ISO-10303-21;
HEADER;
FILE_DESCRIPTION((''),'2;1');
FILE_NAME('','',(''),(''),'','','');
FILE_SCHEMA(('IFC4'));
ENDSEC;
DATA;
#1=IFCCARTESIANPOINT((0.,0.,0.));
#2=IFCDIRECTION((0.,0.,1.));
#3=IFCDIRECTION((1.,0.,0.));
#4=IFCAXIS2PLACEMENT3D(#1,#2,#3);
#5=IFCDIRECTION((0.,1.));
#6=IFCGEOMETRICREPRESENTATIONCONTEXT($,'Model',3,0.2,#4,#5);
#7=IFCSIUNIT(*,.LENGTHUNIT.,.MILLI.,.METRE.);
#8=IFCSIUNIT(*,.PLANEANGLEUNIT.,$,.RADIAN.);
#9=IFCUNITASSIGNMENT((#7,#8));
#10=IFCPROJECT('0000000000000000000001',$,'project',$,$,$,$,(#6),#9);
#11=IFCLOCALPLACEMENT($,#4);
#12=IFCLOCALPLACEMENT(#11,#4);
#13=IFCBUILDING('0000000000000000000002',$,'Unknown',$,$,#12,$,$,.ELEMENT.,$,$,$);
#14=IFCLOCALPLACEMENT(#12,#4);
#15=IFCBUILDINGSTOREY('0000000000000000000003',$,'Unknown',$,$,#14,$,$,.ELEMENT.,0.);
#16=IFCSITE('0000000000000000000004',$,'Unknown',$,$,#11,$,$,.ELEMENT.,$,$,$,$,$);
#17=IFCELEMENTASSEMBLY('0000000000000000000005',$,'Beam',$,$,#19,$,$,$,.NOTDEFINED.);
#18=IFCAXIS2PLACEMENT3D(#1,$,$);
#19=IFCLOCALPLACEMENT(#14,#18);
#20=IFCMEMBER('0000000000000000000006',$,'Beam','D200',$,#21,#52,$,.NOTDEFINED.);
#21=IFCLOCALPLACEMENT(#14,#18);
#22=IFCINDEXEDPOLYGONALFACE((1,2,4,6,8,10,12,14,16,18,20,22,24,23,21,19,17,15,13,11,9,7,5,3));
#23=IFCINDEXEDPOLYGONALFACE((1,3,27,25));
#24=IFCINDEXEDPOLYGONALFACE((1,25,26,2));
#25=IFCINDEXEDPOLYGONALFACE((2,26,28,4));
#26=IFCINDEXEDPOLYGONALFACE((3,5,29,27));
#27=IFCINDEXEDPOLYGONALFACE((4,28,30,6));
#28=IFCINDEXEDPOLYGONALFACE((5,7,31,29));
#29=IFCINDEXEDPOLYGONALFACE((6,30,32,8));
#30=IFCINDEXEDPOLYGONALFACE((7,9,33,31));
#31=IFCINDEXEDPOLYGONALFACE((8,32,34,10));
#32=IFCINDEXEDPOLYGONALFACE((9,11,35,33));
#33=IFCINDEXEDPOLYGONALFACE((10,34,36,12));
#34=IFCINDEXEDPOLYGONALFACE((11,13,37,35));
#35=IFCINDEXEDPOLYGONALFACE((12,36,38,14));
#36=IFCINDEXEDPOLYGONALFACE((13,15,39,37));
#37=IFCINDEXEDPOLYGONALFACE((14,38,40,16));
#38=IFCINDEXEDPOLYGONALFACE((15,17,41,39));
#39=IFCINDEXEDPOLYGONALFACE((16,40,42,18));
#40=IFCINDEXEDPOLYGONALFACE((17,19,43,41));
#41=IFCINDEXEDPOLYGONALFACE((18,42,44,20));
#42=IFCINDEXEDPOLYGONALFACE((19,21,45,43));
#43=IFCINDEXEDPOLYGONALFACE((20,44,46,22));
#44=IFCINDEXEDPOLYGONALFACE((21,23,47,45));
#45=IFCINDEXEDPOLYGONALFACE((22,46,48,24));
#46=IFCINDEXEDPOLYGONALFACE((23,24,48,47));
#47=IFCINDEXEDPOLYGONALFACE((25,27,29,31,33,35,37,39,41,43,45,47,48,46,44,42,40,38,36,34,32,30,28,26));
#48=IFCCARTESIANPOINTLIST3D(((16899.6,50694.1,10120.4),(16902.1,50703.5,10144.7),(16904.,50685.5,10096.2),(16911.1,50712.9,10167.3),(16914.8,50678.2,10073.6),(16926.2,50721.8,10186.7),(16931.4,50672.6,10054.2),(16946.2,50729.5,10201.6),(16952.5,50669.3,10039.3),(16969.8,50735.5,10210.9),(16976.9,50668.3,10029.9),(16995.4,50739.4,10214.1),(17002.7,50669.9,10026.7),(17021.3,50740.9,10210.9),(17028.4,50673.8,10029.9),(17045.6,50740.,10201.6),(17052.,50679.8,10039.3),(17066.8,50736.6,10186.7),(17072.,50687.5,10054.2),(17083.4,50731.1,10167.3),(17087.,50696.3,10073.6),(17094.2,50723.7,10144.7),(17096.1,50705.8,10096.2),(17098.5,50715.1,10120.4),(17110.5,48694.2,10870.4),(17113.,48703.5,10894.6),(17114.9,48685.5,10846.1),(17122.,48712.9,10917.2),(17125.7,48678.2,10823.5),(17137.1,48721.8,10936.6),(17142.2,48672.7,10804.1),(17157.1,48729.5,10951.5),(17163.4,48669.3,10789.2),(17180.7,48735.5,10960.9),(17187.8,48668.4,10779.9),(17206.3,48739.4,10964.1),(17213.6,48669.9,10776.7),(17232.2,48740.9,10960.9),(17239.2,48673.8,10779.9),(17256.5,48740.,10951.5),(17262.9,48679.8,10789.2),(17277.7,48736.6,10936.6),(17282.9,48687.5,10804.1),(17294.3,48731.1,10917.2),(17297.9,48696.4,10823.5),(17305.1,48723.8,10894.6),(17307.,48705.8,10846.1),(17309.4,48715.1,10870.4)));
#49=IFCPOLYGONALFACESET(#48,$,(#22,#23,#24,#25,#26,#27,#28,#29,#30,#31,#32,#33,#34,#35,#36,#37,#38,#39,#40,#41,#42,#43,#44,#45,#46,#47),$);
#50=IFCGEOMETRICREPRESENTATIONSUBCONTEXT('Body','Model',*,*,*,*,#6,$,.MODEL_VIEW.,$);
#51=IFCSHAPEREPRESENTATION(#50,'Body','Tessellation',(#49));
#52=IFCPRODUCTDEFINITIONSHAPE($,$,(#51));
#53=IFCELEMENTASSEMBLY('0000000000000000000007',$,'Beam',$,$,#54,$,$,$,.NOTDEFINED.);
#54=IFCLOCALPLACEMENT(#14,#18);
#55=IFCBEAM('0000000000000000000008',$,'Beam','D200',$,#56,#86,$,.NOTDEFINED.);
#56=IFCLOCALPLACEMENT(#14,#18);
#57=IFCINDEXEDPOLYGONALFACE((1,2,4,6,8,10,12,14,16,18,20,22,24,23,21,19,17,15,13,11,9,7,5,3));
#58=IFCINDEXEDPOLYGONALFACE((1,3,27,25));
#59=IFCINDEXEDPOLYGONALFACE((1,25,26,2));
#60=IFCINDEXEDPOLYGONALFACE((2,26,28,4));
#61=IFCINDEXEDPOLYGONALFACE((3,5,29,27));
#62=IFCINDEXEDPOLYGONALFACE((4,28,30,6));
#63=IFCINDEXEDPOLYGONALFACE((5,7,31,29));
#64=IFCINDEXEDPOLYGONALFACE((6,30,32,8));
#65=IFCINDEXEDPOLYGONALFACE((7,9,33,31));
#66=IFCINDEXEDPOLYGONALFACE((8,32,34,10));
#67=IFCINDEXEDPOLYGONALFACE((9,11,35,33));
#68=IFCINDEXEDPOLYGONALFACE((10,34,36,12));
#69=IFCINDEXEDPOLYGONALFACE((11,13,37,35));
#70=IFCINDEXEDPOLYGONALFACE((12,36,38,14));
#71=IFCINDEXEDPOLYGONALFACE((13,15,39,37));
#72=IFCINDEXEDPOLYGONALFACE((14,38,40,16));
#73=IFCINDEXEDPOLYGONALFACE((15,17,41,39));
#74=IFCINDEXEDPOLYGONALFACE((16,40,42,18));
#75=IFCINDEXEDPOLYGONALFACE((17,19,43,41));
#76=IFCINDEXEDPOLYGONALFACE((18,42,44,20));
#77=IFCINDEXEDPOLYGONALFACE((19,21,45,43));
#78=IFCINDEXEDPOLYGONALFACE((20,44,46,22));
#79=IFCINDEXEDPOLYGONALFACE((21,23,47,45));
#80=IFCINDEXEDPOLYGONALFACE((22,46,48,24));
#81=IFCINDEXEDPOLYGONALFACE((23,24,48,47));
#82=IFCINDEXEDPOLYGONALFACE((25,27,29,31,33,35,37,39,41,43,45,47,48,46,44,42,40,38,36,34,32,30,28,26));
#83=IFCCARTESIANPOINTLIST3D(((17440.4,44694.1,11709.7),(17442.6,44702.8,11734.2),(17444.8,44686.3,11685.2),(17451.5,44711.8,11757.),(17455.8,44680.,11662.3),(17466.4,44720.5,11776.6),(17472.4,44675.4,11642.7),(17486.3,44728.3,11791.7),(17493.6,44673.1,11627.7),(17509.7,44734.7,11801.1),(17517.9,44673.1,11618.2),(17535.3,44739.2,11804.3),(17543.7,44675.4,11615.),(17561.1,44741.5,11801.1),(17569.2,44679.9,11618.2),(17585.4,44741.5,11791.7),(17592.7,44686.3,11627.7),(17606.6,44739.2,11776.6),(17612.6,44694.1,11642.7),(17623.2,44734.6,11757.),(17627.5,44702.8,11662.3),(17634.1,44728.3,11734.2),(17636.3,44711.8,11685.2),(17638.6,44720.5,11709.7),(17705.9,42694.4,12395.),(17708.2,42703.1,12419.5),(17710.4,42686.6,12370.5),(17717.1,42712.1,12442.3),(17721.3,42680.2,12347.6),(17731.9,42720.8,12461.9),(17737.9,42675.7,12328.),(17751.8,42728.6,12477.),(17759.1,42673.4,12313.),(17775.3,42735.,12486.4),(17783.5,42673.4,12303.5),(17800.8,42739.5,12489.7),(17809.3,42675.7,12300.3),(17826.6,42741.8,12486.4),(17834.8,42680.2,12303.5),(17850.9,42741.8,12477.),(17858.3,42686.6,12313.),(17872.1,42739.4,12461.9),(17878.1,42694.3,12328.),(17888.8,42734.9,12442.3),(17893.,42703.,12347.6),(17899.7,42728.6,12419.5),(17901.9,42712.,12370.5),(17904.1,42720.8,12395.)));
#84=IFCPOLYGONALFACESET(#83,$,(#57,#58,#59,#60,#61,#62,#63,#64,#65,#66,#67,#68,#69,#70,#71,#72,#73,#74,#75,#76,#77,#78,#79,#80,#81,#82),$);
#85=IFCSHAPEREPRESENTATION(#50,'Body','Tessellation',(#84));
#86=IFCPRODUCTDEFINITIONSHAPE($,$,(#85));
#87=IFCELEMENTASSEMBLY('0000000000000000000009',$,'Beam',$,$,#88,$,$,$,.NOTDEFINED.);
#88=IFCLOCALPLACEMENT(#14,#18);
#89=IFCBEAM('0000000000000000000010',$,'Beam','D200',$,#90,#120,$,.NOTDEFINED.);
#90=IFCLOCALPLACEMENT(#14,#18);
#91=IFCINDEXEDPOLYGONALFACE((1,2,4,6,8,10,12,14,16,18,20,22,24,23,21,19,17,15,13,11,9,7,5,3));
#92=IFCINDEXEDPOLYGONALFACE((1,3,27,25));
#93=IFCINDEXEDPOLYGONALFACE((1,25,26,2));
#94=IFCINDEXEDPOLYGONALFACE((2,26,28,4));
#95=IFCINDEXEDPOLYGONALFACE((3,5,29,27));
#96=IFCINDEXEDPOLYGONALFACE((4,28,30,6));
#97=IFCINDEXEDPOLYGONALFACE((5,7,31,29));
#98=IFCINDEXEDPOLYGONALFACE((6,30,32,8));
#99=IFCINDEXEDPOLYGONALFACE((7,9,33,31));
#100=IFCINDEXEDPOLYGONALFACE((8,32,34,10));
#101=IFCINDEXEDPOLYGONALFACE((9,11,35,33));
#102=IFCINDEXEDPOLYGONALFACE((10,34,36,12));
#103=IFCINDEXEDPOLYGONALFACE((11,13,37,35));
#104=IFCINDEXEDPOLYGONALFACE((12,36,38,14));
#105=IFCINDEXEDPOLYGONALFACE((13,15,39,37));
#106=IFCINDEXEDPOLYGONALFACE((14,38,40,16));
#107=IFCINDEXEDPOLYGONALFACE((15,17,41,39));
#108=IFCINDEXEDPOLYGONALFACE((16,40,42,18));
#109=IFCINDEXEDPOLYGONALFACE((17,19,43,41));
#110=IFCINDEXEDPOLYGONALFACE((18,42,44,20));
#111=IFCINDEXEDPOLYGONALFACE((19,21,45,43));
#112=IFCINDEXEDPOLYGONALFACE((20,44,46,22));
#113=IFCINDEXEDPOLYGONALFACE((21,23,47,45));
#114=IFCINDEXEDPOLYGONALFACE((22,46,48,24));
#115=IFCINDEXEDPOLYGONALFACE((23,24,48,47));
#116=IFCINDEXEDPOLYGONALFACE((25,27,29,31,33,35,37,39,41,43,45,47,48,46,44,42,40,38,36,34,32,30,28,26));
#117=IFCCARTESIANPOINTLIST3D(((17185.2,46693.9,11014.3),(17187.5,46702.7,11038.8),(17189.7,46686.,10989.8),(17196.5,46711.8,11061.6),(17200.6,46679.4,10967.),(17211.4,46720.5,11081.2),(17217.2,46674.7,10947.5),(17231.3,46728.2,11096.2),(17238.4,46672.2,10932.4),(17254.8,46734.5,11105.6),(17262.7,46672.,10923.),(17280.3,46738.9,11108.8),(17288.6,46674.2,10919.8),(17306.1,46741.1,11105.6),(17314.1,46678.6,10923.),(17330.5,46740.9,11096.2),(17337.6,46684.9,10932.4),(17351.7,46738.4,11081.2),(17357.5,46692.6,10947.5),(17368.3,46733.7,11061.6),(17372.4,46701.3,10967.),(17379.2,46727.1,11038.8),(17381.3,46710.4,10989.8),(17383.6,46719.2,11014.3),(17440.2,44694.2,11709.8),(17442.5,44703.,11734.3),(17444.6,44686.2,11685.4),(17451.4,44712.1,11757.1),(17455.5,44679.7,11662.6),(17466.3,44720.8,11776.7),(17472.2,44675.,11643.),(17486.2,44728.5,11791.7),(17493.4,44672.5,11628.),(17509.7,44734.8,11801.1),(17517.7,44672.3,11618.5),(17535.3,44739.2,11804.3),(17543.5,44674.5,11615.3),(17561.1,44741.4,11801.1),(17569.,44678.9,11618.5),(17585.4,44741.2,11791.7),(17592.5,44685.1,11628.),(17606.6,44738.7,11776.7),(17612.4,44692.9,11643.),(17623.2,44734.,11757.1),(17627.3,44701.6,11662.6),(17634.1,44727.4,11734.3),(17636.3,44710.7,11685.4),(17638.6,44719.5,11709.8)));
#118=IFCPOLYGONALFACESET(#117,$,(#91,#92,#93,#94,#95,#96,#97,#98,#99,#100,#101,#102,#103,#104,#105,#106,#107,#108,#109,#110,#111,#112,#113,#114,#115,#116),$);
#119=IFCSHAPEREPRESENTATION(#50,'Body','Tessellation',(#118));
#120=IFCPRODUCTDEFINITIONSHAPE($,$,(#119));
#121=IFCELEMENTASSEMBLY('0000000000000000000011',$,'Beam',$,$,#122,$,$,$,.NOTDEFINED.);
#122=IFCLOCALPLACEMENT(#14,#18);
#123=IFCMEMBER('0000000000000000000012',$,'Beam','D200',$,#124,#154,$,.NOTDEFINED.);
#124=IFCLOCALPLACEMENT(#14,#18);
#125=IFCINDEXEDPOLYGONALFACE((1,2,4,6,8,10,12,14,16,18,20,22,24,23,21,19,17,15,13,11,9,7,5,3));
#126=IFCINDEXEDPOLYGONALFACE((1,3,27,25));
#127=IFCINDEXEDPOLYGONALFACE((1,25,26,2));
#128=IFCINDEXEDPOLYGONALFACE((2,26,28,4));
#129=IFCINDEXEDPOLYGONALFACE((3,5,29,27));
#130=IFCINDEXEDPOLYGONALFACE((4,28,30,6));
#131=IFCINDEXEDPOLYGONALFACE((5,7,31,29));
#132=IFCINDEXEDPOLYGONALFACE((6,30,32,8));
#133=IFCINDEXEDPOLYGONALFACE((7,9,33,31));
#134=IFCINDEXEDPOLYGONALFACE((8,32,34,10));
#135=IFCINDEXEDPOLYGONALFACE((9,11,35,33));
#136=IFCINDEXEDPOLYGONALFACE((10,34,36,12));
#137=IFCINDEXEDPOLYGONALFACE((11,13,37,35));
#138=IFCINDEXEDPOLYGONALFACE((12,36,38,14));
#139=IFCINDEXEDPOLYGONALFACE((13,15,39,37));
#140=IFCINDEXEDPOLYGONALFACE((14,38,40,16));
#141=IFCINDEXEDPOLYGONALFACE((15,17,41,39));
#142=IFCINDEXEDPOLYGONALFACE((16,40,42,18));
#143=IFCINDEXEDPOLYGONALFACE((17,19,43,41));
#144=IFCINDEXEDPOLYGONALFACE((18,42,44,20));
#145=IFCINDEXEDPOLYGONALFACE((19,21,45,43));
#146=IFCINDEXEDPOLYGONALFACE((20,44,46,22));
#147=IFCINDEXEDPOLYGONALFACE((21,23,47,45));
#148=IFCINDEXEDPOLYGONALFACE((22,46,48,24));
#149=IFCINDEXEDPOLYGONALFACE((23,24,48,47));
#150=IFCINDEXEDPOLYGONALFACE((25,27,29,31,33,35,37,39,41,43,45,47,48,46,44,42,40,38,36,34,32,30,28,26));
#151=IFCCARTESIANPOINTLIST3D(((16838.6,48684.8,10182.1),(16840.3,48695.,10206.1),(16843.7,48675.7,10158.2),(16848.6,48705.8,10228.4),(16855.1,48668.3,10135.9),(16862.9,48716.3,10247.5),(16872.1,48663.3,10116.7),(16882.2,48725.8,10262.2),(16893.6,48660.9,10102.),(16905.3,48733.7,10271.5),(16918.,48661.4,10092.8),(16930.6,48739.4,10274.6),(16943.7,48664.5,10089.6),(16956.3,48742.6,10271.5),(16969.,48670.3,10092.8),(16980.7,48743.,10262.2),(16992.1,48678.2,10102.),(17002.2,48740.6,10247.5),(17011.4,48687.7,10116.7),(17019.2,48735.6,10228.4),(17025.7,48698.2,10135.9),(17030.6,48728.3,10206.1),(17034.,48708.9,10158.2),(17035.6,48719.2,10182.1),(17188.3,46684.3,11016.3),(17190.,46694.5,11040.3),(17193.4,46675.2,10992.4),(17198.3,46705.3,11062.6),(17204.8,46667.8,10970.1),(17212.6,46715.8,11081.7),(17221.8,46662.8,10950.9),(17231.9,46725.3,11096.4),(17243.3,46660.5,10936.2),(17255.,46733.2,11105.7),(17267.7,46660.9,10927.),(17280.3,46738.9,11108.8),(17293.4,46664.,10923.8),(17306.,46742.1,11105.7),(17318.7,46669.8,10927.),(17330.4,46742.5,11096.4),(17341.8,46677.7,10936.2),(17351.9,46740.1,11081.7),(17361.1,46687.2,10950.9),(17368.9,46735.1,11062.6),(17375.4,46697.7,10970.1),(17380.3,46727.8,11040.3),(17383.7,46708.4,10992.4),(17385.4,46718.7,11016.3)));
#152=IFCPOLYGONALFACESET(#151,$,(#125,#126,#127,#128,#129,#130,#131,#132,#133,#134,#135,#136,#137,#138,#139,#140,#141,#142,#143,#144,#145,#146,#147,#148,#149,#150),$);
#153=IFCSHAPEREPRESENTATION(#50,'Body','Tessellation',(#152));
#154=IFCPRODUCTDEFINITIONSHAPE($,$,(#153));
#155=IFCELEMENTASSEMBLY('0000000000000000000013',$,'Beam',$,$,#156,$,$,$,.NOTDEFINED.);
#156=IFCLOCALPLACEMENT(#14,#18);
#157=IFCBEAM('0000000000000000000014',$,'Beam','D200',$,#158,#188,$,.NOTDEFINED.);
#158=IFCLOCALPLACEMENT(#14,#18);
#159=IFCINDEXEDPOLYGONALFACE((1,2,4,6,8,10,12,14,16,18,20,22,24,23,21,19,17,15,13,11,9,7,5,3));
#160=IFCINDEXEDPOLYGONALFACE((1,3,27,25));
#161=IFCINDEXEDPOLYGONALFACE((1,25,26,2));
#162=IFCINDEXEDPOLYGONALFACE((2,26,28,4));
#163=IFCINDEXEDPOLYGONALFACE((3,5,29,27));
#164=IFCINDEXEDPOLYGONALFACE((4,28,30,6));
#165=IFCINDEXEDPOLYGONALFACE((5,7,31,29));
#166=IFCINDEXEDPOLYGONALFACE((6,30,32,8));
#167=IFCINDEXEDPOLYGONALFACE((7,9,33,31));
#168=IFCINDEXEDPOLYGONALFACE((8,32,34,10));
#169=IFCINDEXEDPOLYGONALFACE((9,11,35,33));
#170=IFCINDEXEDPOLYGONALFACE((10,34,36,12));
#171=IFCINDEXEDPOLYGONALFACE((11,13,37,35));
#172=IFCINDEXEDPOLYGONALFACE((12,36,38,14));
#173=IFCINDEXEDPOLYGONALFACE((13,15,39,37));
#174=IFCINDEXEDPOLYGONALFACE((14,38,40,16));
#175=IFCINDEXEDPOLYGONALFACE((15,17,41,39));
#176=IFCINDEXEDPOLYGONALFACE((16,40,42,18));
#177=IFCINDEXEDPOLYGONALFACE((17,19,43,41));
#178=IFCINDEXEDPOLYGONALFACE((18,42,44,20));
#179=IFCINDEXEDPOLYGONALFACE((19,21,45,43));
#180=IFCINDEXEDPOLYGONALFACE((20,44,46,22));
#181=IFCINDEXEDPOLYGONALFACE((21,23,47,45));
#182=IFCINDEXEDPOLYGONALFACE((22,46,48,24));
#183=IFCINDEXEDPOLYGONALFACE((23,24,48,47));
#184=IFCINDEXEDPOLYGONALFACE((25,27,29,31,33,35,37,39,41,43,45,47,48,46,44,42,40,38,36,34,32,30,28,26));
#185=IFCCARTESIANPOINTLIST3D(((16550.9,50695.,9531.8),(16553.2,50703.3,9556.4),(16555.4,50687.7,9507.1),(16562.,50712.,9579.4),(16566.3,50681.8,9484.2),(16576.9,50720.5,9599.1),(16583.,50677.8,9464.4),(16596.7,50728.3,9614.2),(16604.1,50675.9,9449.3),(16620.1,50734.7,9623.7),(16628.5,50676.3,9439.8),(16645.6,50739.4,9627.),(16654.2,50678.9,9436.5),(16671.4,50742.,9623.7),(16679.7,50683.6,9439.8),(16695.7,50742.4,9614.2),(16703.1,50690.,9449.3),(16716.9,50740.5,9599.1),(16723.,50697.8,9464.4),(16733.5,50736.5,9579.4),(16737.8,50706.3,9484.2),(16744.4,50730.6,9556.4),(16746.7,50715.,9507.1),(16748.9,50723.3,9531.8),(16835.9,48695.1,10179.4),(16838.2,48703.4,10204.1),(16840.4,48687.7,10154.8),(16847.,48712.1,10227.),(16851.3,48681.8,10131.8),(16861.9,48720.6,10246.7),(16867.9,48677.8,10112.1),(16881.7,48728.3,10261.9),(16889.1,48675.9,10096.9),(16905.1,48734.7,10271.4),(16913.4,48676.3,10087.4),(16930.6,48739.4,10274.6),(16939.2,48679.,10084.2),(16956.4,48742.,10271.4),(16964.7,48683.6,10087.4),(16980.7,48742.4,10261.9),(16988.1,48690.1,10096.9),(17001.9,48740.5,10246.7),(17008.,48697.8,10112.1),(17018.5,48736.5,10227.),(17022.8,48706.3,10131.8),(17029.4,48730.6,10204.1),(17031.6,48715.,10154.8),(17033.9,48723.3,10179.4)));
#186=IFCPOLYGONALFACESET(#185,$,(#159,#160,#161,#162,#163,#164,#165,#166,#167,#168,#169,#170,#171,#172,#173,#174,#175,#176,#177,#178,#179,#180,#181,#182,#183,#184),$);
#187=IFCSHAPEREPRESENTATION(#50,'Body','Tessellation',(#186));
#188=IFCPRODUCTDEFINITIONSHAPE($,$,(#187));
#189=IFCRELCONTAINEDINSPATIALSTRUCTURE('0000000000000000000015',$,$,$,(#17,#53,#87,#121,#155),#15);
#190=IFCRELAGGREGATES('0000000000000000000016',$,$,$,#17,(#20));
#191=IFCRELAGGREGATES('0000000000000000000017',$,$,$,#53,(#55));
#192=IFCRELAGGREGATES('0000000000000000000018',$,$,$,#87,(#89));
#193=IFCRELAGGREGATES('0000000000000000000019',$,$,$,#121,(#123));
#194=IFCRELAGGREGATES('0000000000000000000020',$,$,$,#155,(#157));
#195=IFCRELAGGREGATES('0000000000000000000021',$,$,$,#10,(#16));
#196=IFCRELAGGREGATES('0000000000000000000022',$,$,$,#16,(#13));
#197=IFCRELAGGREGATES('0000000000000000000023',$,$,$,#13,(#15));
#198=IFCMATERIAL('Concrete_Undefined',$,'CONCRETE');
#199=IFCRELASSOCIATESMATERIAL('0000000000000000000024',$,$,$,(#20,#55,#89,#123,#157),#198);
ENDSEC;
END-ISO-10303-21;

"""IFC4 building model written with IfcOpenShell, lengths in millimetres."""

from ifc_helpers import new_model, si_unit, direction, frame, origin_with_axes, place, context, subcontext, project, spatial, line, indexed_curve, outline, extrude, material, element, aggregate, save


model = new_model("IFC4")

# Units and contexts
model_context = context("Model", 3, precision=0.2, world=origin_with_axes(), true_north=direction((0.0, 1.0)))
body_context = subcontext(model_context, "Body", "Model", "MODEL_VIEW")
ifc_project = project(units=[si_unit("LENGTHUNIT", "METRE", prefix="MILLI"), si_unit("PLANEANGLEUNIT", "RADIAN")], contexts=[model_context])

# Site, building, storey
site_placement = place(None, origin_with_axes())
site = spatial("IfcSite", under=ifc_project, at=site_placement, Name="Unknown", CompositionType="ELEMENT")
building_placement = place(site_placement, origin_with_axes())
building = spatial("IfcBuilding", under=site, at=building_placement, Name="Unknown", CompositionType="ELEMENT")
storey_placement = place(building_placement, origin_with_axes())
storey = spatial("IfcBuildingStorey", under=building, at=storey_placement, Name="Unknown", CompositionType="ELEMENT", Elevation=0.0)

# Shared definitions
ifc_material = material(Name="Concrete_Undefined", Category="CONCRETE")

# Element assembly, member
assembly_1_placement = place(storey_placement, frame((16999.1, 50704.6, 10120.4), z_axis=(-0.994487, -0.10486, 0.0), x_axis=(0.098251, -0.931805, 0.349408)))
assembly_1 = element("IfcElementAssembly", 1, at=assembly_1_placement, inside=storey, Name="Beam", PredefinedType="NOTDEFINED")
member_1_placement = place(assembly_1_placement, origin_with_axes())
member_1 = element("IfcMember", 2, at=member_1_placement, material=ifc_material, Name="Beam", Description="D200", PredefinedType="NOTDEFINED", context=body_context, shape_type="SolidModel", body=[
    extrude(outline(indexed_curve([(100.0, 0.0), (96.6, 25.9), (86.6, 50.0), (70.7, 70.7), (50.0, 86.6), (25.9, 96.6), (0.0, 100.0), (-25.9, 96.6), (-50.0, 86.6), (-70.7, 70.7), (-86.6, 50.0), (-96.6, 25.9), (-100.0, 0.0), (-96.6, -25.9), (-86.6, -50.0), (-70.7, -70.7), (-50.0, -86.6), (-25.9, -96.6), (0.0, -100.0), (25.9, -96.6), (50.0, -86.6), (70.7, -70.7), (86.6, -50.0), (96.6, -25.9)], segments=[line(1, 2, 3, 4, 5, 6, 7, 8, 9, 10, 11, 12, 13, 14, 15, 16, 17, 18, 19, 20, 21, 22, 23, 24, 1)])), frame((0.0, 0.0, 0.0), z_axis=(-1.0, 0.0, 0.0), x_axis=(0.0, 0.0, 1.0)), (0.0, 0.0, -1.0), 2146.3),
])
aggregate(assembly_1, [member_1])

# Element assemblies, beams
assembly_2_placement = place(storey_placement, frame((17539.5, 44707.3, 11709.7), z_axis=(-0.991299, -0.13163, 0.0), x_axis=(0.124634, -0.938613, 0.32167)))
assembly_2 = element("IfcElementAssembly", 3, at=assembly_2_placement, inside=storey, Name="Beam", PredefinedType="NOTDEFINED")
beam_1_placement = place(assembly_2_placement, origin_with_axes())
beam_1 = element("IfcBeam", 4, at=beam_1_placement, material=ifc_material, Name="Beam", Description="D200", PredefinedType="NOTDEFINED", context=body_context, shape_type="SolidModel", body=[
    extrude(outline(indexed_curve([(100.0, 0.0), (96.6, 25.9), (86.6, 50.0), (70.7, 70.7), (50.0, 86.6), (25.9, 96.6), (0.0, 100.0), (-25.9, 96.6), (-50.0, 86.6), (-70.7, 70.7), (-86.6, 50.0), (-96.6, 25.9), (-100.0, 0.0), (-96.6, -25.9), (-86.6, -50.0), (-70.7, -70.7), (-50.0, -86.6), (-25.9, -96.6), (0.0, -100.0), (25.9, -96.6), (50.0, -86.6), (70.7, -70.7), (86.6, -50.0), (96.6, -25.9)], segments=[line(1, 2, 3, 4, 5, 6, 7, 8, 9, 10, 11, 12, 13, 14, 15, 16, 17, 18, 19, 20, 21, 22, 23, 24, 1)])), frame((0.0, 0.0, 0.0), z_axis=(-1.0, 0.0, 0.0), x_axis=(0.0, 0.0, 1.0)), (0.0, 0.0, -1.0), 2130.5),
])
aggregate(assembly_2, [beam_1])
assembly_3_placement = place(storey_placement, frame((17284.4, 46706.6, 11014.3), z_axis=(-0.991971, -0.126468, 0.0), x_axis=(0.119553, -0.937729, 0.326147)))
assembly_3 = element("IfcElementAssembly", 5, at=assembly_3_placement, inside=storey, Name="Beam", PredefinedType="NOTDEFINED")
beam_2_placement = place(assembly_3_placement, origin_with_axes())
beam_2 = element("IfcBeam", 6, at=beam_2_placement, material=ifc_material, Name="Beam", Description="D200", PredefinedType="NOTDEFINED", context=body_context, shape_type="SolidModel", body=[
    extrude(outline(indexed_curve([(100.0, 0.0), (96.6, 25.9), (86.6, 50.0), (70.7, 70.7), (50.0, 86.6), (25.9, 96.6), (0.0, 100.0), (-25.9, 96.6), (-50.0, 86.6), (-70.7, 70.7), (-86.6, 50.0), (-96.6, 25.9), (-100.0, 0.0), (-96.6, -25.9), (-86.6, -50.0), (-70.7, -70.7), (-50.0, -86.6), (-25.9, -96.6), (0.0, -100.0), (25.9, -96.6), (50.0, -86.6), (70.7, -70.7), (86.6, -50.0), (96.6, -25.9)], segments=[line(1, 2, 3, 4, 5, 6, 7, 8, 9, 10, 11, 12, 13, 14, 15, 16, 17, 18, 19, 20, 21, 22, 23, 24, 1)])), frame((0.0, 0.0, 0.0), z_axis=(-1.0, 0.0, 0.0), x_axis=(0.0, 0.0, 1.0)), (0.0, 0.0, -1.0), 2132.5),
])
aggregate(assembly_3, [beam_2])

# Element assembly, member
assembly_4_placement = place(storey_placement, frame((16937.1, 48702.0, 10182.1), z_axis=(-0.985062, -0.172199, 0.0), x_axis=(0.159285, -0.911185, 0.379962)))
assembly_4 = element("IfcElementAssembly", 7, at=assembly_4_placement, inside=storey, Name="Beam", PredefinedType="NOTDEFINED")
member_2_placement = place(assembly_4_placement, origin_with_axes())
member_2 = element("IfcMember", 8, at=member_2_placement, material=ifc_material, Name="Beam", Description="D200", PredefinedType="NOTDEFINED", context=body_context, shape_type="SolidModel", body=[
    extrude(outline(indexed_curve([(100.0, 0.0), (96.6, 25.9), (86.6, 50.0), (70.7, 70.7), (50.0, 86.6), (25.9, 96.6), (0.0, 100.0), (-25.9, 96.6), (-50.0, 86.6), (-70.7, 70.7), (-86.6, 50.0), (-96.6, 25.9), (-100.0, 0.0), (-96.6, -25.9), (-86.6, -50.0), (-70.7, -70.7), (-50.0, -86.6), (-25.9, -96.6), (0.0, -100.0), (25.9, -96.6), (50.0, -86.6), (70.7, -70.7), (86.6, -50.0), (96.6, -25.9)], segments=[line(1, 2, 3, 4, 5, 6, 7, 8, 9, 10, 11, 12, 13, 14, 15, 16, 17, 18, 19, 20, 21, 22, 23, 24, 1)])), frame((0.0, 0.0, 0.0), z_axis=(-1.0, 0.0, 0.0), x_axis=(0.0, 0.0, 1.0)), (0.0, 0.0, -1.0), 2195.5),
])
aggregate(assembly_4, [member_2])

# Element assembly, beam
assembly_5_placement = place(storey_placement, frame((16649.9, 50709.2, 9531.8), z_axis=(-0.989999, -0.141072, 0.0), x_axis=(0.134337, -0.942739, 0.305283)))
assembly_5 = element("IfcElementAssembly", 9, at=assembly_5_placement, inside=storey, Name="Beam", PredefinedType="NOTDEFINED")
beam_3_placement = place(assembly_5_placement, origin_with_axes())
beam_3 = element("IfcBeam", 10, at=beam_3_placement, material=ifc_material, Name="Beam", Description="D200", PredefinedType="NOTDEFINED", context=body_context, shape_type="SolidModel", body=[
    extrude(outline(indexed_curve([(100.0, 0.0), (96.6, 25.9), (86.6, 50.0), (70.7, 70.7), (50.0, 86.6), (25.9, 96.6), (0.0, 100.0), (-25.9, 96.6), (-50.0, 86.6), (-70.7, 70.7), (-86.6, 50.0), (-96.6, 25.9), (-100.0, 0.0), (-96.6, -25.9), (-86.6, -50.0), (-70.7, -70.7), (-50.0, -86.6), (-25.9, -96.6), (0.0, -100.0), (25.9, -96.6), (50.0, -86.6), (70.7, -70.7), (86.6, -50.0), (96.6, -25.9)], segments=[line(1, 2, 3, 4, 5, 6, 7, 8, 9, 10, 11, 12, 13, 14, 15, 16, 17, 18, 19, 20, 21, 22, 23, 24, 1)])), frame((0.0, 0.0, 0.0), z_axis=(-1.0, 0.0, 0.0), x_axis=(0.0, 0.0, 1.0)), (0.0, 0.0, -1.0), 2121.5),
])
aggregate(assembly_5, [beam_3])

save(model, "model.ifc")
